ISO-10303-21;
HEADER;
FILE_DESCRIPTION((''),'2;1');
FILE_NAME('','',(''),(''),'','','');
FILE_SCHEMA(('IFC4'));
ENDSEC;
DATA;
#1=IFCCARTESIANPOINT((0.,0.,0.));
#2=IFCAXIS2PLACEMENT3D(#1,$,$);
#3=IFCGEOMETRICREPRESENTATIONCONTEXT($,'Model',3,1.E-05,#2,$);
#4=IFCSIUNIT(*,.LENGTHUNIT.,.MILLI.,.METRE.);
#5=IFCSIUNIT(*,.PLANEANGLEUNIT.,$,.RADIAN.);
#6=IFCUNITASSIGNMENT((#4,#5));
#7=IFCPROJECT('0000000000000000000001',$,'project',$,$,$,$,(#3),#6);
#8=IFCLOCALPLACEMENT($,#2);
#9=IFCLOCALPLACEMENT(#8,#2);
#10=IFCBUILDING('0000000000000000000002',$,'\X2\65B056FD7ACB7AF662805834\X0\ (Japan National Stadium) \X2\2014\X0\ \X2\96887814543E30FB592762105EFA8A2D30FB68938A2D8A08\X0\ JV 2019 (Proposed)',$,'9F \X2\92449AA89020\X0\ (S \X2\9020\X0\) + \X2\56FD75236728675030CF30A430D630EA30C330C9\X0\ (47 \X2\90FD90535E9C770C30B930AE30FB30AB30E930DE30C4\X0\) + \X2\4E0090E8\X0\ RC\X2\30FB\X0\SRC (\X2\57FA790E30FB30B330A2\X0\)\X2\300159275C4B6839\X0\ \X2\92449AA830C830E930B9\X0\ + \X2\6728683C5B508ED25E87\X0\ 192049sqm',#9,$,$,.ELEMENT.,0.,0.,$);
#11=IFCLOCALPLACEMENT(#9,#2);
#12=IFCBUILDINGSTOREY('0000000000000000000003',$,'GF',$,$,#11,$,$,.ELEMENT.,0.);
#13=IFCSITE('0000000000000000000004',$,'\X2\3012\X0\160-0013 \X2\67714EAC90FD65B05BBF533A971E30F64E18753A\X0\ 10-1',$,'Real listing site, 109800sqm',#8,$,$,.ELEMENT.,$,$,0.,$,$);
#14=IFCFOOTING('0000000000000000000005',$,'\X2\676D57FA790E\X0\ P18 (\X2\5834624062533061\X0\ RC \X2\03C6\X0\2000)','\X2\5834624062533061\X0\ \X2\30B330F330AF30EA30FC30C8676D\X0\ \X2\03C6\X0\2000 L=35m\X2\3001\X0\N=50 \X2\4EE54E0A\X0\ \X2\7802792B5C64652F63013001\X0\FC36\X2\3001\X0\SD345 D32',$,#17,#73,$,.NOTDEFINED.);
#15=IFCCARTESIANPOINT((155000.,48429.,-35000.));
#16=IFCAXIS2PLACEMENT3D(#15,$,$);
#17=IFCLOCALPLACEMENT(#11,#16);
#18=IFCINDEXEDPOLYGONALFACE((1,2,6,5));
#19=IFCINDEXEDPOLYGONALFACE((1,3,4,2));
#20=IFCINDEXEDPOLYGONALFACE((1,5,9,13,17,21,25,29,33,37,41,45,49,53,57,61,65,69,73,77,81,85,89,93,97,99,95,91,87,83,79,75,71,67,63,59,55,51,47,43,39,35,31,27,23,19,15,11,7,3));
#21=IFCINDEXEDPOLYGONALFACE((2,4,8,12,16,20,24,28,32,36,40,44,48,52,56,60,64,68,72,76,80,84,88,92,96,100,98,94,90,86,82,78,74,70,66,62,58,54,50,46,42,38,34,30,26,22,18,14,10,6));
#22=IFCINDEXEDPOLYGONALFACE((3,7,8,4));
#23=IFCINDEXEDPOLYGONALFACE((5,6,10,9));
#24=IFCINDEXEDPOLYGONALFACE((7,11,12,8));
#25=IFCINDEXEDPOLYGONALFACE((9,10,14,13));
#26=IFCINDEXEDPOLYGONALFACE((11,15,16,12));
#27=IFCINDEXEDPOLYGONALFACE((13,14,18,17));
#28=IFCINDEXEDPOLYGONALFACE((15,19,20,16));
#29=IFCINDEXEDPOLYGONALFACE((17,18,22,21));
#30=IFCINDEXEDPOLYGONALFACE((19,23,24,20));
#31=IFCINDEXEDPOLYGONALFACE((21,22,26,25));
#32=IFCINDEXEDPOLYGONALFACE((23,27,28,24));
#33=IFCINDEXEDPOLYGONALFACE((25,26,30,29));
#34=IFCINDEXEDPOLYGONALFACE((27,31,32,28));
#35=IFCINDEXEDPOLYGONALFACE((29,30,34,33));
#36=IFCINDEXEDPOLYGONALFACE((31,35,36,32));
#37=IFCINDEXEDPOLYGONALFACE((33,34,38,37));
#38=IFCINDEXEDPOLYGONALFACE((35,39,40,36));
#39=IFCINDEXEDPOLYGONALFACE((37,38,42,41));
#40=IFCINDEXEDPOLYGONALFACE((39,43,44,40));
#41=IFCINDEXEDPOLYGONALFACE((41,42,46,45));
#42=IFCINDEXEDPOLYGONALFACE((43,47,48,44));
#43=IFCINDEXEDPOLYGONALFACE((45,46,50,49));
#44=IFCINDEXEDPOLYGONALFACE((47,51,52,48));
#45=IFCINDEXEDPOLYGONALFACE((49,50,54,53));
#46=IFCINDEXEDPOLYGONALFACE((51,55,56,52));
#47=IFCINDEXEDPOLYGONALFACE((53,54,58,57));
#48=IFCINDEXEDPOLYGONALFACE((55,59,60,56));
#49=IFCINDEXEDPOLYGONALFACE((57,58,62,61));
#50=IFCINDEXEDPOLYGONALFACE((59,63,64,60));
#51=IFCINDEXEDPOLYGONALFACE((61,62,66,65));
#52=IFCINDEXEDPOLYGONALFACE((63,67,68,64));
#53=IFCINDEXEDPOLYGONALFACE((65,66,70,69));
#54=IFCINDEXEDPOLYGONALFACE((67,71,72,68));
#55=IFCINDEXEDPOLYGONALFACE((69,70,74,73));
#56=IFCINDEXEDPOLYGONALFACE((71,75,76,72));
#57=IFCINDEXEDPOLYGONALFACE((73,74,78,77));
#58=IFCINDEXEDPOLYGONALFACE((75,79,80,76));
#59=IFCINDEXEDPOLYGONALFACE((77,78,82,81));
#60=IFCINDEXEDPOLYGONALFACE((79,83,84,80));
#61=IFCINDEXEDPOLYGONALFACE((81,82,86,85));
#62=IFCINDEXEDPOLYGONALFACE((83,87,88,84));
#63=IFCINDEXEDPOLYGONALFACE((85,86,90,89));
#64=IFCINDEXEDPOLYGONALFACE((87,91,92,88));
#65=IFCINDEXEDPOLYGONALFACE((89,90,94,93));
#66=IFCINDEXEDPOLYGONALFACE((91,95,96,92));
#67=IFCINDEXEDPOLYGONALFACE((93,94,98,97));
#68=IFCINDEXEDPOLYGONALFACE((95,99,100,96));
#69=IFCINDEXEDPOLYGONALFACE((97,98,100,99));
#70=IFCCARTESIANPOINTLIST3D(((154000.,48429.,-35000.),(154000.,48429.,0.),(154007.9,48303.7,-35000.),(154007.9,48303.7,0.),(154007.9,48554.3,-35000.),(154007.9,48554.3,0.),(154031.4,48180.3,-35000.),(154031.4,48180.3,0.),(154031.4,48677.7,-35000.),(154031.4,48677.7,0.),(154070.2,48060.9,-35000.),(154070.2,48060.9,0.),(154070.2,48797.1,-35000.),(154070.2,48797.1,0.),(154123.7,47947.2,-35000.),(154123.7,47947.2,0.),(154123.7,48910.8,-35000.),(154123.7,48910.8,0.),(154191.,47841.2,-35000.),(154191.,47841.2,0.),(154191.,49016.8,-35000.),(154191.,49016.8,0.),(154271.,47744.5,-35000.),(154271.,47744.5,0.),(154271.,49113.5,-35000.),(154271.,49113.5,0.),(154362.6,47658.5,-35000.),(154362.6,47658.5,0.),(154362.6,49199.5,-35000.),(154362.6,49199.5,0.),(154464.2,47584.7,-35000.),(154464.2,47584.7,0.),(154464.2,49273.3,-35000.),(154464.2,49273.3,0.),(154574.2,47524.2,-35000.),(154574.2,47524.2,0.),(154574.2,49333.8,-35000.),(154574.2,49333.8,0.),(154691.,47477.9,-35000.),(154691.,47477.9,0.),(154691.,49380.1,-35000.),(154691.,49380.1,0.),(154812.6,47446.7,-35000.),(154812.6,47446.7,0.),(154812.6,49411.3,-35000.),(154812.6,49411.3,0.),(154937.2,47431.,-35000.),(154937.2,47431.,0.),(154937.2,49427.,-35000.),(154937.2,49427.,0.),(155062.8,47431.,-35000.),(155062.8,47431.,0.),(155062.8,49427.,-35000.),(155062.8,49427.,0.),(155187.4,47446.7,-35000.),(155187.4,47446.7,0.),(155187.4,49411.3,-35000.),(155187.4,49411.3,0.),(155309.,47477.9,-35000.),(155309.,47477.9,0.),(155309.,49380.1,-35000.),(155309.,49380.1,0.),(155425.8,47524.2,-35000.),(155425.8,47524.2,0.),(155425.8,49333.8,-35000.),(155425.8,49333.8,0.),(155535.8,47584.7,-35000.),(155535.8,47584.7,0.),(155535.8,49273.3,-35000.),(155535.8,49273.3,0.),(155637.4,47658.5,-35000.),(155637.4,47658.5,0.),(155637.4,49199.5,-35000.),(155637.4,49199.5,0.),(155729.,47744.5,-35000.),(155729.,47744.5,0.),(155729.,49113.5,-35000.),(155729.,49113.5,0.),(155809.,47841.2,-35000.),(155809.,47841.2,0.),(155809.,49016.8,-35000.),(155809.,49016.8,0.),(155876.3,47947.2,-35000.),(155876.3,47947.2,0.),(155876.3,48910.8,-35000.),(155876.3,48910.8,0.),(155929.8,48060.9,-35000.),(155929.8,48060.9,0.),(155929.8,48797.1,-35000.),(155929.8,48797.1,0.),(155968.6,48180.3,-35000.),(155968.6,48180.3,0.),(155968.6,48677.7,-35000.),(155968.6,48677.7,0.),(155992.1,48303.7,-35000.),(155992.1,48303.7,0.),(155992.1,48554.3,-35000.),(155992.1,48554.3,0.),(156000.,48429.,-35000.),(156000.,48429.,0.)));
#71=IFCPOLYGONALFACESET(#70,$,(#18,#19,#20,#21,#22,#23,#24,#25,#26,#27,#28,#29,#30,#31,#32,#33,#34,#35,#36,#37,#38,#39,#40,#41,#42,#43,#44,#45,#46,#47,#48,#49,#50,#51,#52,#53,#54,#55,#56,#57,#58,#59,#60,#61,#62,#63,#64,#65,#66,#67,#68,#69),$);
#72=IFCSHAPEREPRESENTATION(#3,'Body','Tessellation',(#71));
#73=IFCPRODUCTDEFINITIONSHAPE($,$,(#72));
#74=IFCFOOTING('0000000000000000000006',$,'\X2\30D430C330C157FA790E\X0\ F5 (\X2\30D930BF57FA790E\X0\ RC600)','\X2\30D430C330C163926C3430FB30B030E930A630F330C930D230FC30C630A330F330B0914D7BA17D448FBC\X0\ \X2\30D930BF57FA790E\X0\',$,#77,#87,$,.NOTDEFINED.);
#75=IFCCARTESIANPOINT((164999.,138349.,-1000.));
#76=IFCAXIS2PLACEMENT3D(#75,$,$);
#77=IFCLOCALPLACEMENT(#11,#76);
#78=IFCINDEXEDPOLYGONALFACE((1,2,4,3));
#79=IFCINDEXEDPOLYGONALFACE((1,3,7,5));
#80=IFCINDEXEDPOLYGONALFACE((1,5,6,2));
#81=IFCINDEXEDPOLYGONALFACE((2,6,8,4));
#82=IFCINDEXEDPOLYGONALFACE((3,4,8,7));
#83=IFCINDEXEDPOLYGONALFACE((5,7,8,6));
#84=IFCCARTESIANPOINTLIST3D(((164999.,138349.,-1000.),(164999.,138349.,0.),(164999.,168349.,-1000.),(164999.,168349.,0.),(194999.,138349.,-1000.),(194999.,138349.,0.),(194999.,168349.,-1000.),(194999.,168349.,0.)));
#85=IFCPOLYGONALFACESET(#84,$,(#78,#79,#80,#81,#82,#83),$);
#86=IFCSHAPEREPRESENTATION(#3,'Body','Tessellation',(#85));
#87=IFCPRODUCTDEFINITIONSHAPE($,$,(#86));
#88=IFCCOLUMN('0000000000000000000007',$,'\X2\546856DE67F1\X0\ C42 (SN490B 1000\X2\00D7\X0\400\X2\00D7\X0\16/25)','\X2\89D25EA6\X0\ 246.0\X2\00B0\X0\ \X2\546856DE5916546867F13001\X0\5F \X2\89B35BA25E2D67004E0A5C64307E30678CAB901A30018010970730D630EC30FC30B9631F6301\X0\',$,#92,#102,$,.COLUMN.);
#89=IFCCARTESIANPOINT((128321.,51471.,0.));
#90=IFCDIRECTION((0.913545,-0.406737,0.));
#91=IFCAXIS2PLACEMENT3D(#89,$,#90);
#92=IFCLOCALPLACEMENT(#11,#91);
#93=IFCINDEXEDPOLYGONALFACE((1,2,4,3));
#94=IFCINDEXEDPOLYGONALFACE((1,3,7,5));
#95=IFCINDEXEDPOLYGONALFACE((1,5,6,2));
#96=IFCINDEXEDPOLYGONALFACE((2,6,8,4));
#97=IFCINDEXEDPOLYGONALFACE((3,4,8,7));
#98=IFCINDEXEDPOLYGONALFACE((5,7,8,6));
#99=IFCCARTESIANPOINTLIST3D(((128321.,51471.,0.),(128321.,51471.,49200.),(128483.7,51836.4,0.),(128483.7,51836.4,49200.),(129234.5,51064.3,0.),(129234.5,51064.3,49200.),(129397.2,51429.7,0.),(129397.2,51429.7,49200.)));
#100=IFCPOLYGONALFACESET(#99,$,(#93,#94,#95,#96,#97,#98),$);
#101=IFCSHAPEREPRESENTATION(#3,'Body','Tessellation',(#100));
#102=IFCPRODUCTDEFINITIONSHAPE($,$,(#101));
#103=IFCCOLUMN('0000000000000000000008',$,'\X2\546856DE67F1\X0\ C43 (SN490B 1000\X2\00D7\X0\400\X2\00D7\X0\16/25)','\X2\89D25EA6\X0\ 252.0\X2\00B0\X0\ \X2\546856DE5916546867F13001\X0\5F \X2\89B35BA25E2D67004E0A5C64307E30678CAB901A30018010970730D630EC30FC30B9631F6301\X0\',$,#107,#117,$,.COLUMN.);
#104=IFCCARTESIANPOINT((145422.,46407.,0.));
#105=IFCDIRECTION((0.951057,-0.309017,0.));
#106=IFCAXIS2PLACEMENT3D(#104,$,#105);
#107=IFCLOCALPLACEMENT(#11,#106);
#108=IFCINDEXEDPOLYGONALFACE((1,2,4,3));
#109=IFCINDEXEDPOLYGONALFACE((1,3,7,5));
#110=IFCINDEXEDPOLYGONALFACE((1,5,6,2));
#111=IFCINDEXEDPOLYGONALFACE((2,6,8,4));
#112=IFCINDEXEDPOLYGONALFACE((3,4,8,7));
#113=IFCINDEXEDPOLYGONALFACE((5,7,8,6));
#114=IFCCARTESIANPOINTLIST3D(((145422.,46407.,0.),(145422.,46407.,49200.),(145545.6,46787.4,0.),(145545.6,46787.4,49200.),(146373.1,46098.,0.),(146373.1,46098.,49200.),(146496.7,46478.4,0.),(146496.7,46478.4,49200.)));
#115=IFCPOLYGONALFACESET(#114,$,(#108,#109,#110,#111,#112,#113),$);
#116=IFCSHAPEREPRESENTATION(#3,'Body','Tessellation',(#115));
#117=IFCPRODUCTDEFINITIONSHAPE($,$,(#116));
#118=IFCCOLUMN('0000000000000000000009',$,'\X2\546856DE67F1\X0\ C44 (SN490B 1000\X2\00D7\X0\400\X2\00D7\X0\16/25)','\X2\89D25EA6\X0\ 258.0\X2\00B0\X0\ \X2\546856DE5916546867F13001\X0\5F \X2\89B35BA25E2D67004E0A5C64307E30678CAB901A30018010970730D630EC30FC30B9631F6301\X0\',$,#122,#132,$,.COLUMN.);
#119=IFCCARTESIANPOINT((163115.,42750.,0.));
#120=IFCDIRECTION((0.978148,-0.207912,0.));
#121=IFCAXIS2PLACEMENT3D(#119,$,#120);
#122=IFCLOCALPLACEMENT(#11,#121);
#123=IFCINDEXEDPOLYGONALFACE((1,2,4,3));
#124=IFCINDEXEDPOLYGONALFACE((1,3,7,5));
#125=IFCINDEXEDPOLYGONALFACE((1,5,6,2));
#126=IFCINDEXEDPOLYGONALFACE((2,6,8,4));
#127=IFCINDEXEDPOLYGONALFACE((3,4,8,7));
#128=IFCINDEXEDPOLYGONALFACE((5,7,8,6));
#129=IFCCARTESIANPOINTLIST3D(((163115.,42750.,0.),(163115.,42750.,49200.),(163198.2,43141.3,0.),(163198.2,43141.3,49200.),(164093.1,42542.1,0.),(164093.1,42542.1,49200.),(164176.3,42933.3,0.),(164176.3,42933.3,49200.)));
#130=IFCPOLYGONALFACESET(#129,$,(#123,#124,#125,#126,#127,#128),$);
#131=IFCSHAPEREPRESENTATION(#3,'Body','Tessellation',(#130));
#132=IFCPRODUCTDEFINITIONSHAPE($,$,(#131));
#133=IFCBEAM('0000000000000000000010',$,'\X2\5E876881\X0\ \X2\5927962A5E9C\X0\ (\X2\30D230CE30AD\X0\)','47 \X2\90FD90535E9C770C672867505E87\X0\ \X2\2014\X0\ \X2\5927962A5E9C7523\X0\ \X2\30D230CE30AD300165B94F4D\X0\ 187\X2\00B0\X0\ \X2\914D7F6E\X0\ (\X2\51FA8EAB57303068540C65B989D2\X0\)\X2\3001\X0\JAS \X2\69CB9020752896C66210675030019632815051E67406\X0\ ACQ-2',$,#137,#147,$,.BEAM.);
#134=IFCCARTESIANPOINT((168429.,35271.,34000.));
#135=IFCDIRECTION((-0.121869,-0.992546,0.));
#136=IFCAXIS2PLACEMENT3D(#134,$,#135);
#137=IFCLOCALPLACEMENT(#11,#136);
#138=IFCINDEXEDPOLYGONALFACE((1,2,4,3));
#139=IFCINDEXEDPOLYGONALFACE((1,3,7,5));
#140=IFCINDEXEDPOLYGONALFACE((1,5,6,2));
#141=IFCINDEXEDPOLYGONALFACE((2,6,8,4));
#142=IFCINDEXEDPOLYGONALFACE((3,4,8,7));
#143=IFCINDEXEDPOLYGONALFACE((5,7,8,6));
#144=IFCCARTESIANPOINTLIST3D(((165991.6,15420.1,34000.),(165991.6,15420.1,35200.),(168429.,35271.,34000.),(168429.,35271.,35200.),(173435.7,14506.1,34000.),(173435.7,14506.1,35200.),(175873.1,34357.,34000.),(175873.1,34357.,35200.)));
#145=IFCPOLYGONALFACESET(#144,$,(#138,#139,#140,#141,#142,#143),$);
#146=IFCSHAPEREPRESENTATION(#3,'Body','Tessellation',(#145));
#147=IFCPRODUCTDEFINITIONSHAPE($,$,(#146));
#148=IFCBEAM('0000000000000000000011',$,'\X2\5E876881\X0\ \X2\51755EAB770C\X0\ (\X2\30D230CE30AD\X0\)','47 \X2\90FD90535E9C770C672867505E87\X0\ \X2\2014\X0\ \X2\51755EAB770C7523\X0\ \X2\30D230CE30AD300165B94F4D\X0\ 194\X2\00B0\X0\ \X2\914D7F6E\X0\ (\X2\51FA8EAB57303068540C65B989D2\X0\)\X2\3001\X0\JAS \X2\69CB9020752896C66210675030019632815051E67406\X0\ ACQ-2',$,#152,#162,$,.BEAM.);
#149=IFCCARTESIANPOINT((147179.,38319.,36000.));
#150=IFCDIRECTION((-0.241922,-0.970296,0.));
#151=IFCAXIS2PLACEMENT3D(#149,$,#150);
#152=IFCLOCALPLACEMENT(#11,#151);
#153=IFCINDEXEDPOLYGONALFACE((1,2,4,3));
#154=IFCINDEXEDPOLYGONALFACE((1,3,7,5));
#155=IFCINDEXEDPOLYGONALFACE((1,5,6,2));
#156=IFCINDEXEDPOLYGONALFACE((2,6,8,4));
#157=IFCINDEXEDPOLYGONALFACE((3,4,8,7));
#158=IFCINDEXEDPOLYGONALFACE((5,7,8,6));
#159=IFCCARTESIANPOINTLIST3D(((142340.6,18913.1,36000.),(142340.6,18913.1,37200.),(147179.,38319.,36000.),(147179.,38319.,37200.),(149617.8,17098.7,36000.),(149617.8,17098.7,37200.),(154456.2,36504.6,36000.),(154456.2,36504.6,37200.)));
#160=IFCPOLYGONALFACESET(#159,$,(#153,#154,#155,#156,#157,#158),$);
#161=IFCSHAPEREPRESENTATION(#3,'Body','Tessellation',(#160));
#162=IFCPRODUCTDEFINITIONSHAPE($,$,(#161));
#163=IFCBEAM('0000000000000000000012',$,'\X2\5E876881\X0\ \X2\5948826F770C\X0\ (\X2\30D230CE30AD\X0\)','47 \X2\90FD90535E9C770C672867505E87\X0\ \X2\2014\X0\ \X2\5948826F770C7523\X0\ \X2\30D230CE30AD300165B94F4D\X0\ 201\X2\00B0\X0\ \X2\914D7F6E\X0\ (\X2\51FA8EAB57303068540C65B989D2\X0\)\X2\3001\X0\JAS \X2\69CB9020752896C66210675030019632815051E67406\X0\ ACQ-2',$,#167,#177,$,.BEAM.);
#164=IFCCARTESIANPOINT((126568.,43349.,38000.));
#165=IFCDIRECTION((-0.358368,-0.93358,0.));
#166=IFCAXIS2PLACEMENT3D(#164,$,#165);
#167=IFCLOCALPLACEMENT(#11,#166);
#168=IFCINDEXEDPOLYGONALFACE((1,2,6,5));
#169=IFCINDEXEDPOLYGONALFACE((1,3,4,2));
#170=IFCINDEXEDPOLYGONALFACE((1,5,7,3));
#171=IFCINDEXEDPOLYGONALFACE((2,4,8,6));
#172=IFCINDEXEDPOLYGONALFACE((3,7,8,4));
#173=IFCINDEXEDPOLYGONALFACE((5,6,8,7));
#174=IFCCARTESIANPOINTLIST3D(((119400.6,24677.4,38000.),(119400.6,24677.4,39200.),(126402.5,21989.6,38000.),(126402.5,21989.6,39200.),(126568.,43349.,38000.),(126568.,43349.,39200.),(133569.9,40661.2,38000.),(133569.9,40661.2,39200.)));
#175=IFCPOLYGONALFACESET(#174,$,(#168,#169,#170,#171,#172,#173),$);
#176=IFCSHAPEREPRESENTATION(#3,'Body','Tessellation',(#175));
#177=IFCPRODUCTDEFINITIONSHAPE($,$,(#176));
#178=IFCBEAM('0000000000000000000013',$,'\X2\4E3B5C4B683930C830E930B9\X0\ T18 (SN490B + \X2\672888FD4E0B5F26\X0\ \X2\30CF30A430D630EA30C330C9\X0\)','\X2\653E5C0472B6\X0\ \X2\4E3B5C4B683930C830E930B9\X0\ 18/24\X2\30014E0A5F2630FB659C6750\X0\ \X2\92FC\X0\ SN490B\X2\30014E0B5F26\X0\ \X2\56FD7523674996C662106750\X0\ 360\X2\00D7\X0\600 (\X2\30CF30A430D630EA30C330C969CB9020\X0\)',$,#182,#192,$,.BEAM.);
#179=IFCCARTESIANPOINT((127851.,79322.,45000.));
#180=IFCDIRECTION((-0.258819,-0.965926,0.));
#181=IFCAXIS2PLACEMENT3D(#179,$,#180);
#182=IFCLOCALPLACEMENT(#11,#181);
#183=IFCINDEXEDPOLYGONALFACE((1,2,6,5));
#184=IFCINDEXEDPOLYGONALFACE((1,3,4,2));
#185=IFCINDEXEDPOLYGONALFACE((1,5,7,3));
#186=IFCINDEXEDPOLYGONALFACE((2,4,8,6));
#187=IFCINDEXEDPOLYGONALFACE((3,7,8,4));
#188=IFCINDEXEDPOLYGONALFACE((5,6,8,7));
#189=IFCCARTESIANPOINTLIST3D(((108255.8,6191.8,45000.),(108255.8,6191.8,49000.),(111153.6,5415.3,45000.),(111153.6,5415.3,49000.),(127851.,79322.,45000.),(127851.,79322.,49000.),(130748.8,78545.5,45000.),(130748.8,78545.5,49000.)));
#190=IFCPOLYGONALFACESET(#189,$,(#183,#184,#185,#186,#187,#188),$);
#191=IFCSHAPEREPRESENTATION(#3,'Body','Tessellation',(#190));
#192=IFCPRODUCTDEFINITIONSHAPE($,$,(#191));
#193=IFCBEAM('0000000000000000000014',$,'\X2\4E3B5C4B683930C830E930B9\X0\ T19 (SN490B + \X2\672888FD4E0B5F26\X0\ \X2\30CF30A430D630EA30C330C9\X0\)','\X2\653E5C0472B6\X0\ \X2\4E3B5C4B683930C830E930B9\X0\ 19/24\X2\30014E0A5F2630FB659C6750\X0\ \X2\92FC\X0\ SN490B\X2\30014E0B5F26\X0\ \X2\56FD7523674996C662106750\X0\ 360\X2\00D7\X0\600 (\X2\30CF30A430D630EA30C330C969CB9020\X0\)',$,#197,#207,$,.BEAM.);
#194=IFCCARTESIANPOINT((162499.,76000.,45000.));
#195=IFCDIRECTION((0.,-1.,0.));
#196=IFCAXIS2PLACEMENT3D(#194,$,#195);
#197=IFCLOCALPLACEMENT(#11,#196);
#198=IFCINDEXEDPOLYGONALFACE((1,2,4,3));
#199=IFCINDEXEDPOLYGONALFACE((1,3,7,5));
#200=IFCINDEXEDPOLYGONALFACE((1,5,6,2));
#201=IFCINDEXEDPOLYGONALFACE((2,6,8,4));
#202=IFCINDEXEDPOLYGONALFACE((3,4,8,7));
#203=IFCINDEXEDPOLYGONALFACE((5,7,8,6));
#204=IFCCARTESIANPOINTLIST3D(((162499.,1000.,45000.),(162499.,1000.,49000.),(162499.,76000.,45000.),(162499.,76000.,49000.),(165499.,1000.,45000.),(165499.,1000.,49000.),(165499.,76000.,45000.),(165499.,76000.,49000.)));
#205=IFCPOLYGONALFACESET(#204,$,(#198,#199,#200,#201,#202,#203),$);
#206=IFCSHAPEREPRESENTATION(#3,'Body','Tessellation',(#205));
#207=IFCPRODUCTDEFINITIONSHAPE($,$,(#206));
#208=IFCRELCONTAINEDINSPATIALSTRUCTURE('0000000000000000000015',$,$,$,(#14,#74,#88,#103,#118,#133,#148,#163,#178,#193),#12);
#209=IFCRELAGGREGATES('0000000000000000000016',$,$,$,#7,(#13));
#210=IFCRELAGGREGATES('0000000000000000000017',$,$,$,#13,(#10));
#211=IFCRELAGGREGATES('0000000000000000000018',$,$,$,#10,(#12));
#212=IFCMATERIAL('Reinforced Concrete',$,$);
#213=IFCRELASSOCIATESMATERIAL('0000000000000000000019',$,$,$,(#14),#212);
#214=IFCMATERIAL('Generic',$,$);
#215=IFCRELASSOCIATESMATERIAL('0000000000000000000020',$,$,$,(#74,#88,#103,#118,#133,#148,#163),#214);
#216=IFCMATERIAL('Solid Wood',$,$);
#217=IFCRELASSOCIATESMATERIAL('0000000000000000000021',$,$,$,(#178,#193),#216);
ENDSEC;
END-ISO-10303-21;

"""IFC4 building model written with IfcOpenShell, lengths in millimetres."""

from ifc_helpers import new_model, si_unit, frame, frame_2d, origin, origin_2d, place, context, project, spatial, rectangle, circle, extrude, material, element, save


model = new_model("IFC4")

# Units and contexts
model_context = context("Model", 3, precision=1e-05, world=origin())
ifc_project = project(units=[si_unit("LENGTHUNIT", "METRE", prefix="MILLI"), si_unit("PLANEANGLEUNIT", "RADIAN")], contexts=[model_context])

# Site, building, storey
site_placement = place(None, origin())
site = spatial("IfcSite", under=ifc_project, at=site_placement, Name="〒160-0013 東京都新宿区霞ヶ丘町 10-1", ObjectType="Real listing site, 109800sqm", CompositionType="ELEMENT", RefElevation=0.0)
building_placement = place(site_placement, origin())
building = spatial("IfcBuilding", under=site, at=building_placement, Name="新国立競技場 (Japan National Stadium) — 隈研吾・大成建設・梓設計 JV 2019 (Proposed)", ObjectType="9F 鉄骨造 (S 造) + 国産木材ハイブリッド (47 都道府県スギ・カラマツ) + 一部 RC・SRC (基礎・コア)、大屋根 鉄骨トラス + 木格子軒庇 192049sqm", CompositionType="ELEMENT", ElevationOfRefHeight=0.0, ElevationOfTerrain=0.0)
storey_placement = place(building_placement, origin())
storey = spatial("IfcBuildingStorey", under=building, at=storey_placement, Name="GF", CompositionType="ELEMENT", Elevation=0.0)

# Footings
ifc_material_1 = material(Name="Reinforced Concrete")
footing_1_placement = place(storey_placement, frame((155000.0, 48429.0, -35000.0)))
element("IfcFooting", 1, at=footing_1_placement, inside=storey, material=ifc_material_1, Name="杭基礎 P18 (場所打ち RC φ2000)", Description="場所打ち コンクリート杭 φ2000 L=35m、N=50 以上 砂礫層支持、FC36、SD345 D32", PredefinedType="NOTDEFINED", context=model_context, shape_type="SweptSolid", body=[
    extrude(circle(Radius=1000.0, at=origin_2d()), frame((155000.0, 48429.0, -35000.0)), (0.0, 0.0, 1.0), 35000.0),
])
ifc_material_2 = material(Name="Generic")
footing_2_placement = place(storey_placement, frame((164999.0, 138349.0, -1000.0)))
element("IfcFooting", 2, at=footing_2_placement, inside=storey, material=ifc_material_2, Name="ピッチ基礎 F5 (ベタ基礎 RC600)", Description="ピッチ排水・グラウンドヒーティング配管組込 ベタ基礎", PredefinedType="NOTDEFINED", context=model_context, shape_type="SweptSolid", body=[
    extrude(rectangle(XDim=30000.0, YDim=30000.0, at=frame_2d((15000.0, 15000.0))), frame((164999.0, 138349.0, -1000.0)), (0.0, 0.0, 1.0), 1000.0),
])

# Columns
column_1_placement = place(storey_placement, frame((128321.0, 51471.0, 0.0), x_axis=(0.913545, -0.406737, 0.0)))
element("IfcColumn", 3, at=column_1_placement, inside=storey, material=ifc_material_2, Name="周回柱 C42 (SN490B 1000×400×16/25)", Description="角度 246.0° 周回外周柱、5F 観客席最上層まで貫通、耐震ブレース挟持", PredefinedType="COLUMN", context=model_context, shape_type="SweptSolid", body=[
    extrude(rectangle(XDim=1000.0, YDim=400.0, at=frame_2d((500.0, 200.0))), frame((128321.0, 51471.0, 0.0), x_axis=(0.913545, -0.406737, 0.0)), (0.0, 0.0, 1.0), 49200.0),
])
column_2_placement = place(storey_placement, frame((145422.0, 46407.0, 0.0), x_axis=(0.951057, -0.309017, 0.0)))
element("IfcColumn", 4, at=column_2_placement, inside=storey, material=ifc_material_2, Name="周回柱 C43 (SN490B 1000×400×16/25)", Description="角度 252.0° 周回外周柱、5F 観客席最上層まで貫通、耐震ブレース挟持", PredefinedType="COLUMN", context=model_context, shape_type="SweptSolid", body=[
    extrude(rectangle(XDim=1000.0, YDim=400.0, at=frame_2d((500.0, 200.0))), frame((145422.0, 46407.0, 0.0), x_axis=(0.951057, -0.309017, 0.0)), (0.0, 0.0, 1.0), 49200.0),
])
column_3_placement = place(storey_placement, frame((163115.0, 42750.0, 0.0), x_axis=(0.978148, -0.207912, 0.0)))
element("IfcColumn", 5, at=column_3_placement, inside=storey, material=ifc_material_2, Name="周回柱 C44 (SN490B 1000×400×16/25)", Description="角度 258.0° 周回外周柱、5F 観客席最上層まで貫通、耐震ブレース挟持", PredefinedType="COLUMN", context=model_context, shape_type="SweptSolid", body=[
    extrude(rectangle(XDim=1000.0, YDim=400.0, at=frame_2d((500.0, 200.0))), frame((163115.0, 42750.0, 0.0), x_axis=(0.978148, -0.207912, 0.0)), (0.0, 0.0, 1.0), 49200.0),
])

# Beams
beam_1_placement = place(storey_placement, frame((168429.0, 35271.0, 34000.0), x_axis=(-0.121869, -0.992546, 0.0)))
element("IfcBeam", 6, at=beam_1_placement, inside=storey, material=ifc_material_2, Name="庇梁 大阪府 (ヒノキ)", Description="47 都道府県木材庇 — 大阪府産 ヒノキ、方位 187° 配置 (出身地と同方角)、JAS 構造用集成材、防腐処理 ACQ-2", PredefinedType="BEAM", context=model_context, shape_type="SweptSolid", body=[
    extrude(rectangle(XDim=20000.0, YDim=7500.0, at=frame_2d((10000.0, 3750.0))), frame((168429.0, 35271.0, 34000.0), x_axis=(-0.121869, -0.992546, 0.0)), (0.0, 0.0, 1.0), 1200.0),
])
beam_2_placement = place(storey_placement, frame((147179.0, 38319.0, 36000.0), x_axis=(-0.241922, -0.970296, 0.0)))
element("IfcBeam", 7, at=beam_2_placement, inside=storey, material=ifc_material_2, Name="庇梁 兵庫県 (ヒノキ)", Description="47 都道府県木材庇 — 兵庫県産 ヒノキ、方位 194° 配置 (出身地と同方角)、JAS 構造用集成材、防腐処理 ACQ-2", PredefinedType="BEAM", context=model_context, shape_type="SweptSolid", body=[
    extrude(rectangle(XDim=20000.0, YDim=7500.0, at=frame_2d((10000.0, 3750.0))), frame((147179.0, 38319.0, 36000.0), x_axis=(-0.241922, -0.970296, 0.0)), (0.0, 0.0, 1.0), 1200.0),
])
beam_3_placement = place(storey_placement, frame((126568.0, 43349.0, 38000.0), x_axis=(-0.358368, -0.93358, 0.0)))
element("IfcBeam", 8, at=beam_3_placement, inside=storey, material=ifc_material_2, Name="庇梁 奈良県 (ヒノキ)", Description="47 都道府県木材庇 — 奈良県産 ヒノキ、方位 201° 配置 (出身地と同方角)、JAS 構造用集成材、防腐処理 ACQ-2", PredefinedType="BEAM", context=model_context, shape_type="SweptSolid", body=[
    extrude(rectangle(XDim=20000.0, YDim=7500.0, at=frame_2d((10000.0, 3750.0))), frame((126568.0, 43349.0, 38000.0), x_axis=(-0.358368, -0.93358, 0.0)), (0.0, 0.0, 1.0), 1200.0),
])
ifc_material_3 = material(Name="Solid Wood")
beam_4_placement = place(storey_placement, frame((127851.0, 79322.0, 45000.0), x_axis=(-0.258819, -0.965926, 0.0)))
element("IfcBeam", 9, at=beam_4_placement, inside=storey, material=ifc_material_3, Name="主屋根トラス T18 (SN490B + 木製下弦 ハイブリッド)", Description="放射状 主屋根トラス 18/24、上弦・斜材 鋼 SN490B、下弦 国産杉集成材 360×600 (ハイブリッド構造)", PredefinedType="BEAM", context=model_context, shape_type="SweptSolid", body=[
    extrude(rectangle(XDim=75710.0, YDim=3000.0, at=frame_2d((37855.0, 1500.0))), frame((127851.0, 79322.0, 45000.0), x_axis=(-0.258819, -0.965926, 0.0)), (0.0, 0.0, 1.0), 4000.0),
])
beam_5_placement = place(storey_placement, frame((162499.0, 76000.0, 45000.0), x_axis=(0.0, -1.0, 0.0)))
element("IfcBeam", 10, at=beam_5_placement, inside=storey, material=ifc_material_3, Name="主屋根トラス T19 (SN490B + 木製下弦 ハイブリッド)", Description="放射状 主屋根トラス 19/24、上弦・斜材 鋼 SN490B、下弦 国産杉集成材 360×600 (ハイブリッド構造)", PredefinedType="BEAM", context=model_context, shape_type="SweptSolid", body=[
    extrude(rectangle(XDim=75000.0, YDim=3000.0, at=frame_2d((37500.0, 1500.0))), frame((162499.0, 76000.0, 45000.0), x_axis=(0.0, -1.0, 0.0)), (0.0, 0.0, 1.0), 4000.0),
])

save(model, "model.ifc")
